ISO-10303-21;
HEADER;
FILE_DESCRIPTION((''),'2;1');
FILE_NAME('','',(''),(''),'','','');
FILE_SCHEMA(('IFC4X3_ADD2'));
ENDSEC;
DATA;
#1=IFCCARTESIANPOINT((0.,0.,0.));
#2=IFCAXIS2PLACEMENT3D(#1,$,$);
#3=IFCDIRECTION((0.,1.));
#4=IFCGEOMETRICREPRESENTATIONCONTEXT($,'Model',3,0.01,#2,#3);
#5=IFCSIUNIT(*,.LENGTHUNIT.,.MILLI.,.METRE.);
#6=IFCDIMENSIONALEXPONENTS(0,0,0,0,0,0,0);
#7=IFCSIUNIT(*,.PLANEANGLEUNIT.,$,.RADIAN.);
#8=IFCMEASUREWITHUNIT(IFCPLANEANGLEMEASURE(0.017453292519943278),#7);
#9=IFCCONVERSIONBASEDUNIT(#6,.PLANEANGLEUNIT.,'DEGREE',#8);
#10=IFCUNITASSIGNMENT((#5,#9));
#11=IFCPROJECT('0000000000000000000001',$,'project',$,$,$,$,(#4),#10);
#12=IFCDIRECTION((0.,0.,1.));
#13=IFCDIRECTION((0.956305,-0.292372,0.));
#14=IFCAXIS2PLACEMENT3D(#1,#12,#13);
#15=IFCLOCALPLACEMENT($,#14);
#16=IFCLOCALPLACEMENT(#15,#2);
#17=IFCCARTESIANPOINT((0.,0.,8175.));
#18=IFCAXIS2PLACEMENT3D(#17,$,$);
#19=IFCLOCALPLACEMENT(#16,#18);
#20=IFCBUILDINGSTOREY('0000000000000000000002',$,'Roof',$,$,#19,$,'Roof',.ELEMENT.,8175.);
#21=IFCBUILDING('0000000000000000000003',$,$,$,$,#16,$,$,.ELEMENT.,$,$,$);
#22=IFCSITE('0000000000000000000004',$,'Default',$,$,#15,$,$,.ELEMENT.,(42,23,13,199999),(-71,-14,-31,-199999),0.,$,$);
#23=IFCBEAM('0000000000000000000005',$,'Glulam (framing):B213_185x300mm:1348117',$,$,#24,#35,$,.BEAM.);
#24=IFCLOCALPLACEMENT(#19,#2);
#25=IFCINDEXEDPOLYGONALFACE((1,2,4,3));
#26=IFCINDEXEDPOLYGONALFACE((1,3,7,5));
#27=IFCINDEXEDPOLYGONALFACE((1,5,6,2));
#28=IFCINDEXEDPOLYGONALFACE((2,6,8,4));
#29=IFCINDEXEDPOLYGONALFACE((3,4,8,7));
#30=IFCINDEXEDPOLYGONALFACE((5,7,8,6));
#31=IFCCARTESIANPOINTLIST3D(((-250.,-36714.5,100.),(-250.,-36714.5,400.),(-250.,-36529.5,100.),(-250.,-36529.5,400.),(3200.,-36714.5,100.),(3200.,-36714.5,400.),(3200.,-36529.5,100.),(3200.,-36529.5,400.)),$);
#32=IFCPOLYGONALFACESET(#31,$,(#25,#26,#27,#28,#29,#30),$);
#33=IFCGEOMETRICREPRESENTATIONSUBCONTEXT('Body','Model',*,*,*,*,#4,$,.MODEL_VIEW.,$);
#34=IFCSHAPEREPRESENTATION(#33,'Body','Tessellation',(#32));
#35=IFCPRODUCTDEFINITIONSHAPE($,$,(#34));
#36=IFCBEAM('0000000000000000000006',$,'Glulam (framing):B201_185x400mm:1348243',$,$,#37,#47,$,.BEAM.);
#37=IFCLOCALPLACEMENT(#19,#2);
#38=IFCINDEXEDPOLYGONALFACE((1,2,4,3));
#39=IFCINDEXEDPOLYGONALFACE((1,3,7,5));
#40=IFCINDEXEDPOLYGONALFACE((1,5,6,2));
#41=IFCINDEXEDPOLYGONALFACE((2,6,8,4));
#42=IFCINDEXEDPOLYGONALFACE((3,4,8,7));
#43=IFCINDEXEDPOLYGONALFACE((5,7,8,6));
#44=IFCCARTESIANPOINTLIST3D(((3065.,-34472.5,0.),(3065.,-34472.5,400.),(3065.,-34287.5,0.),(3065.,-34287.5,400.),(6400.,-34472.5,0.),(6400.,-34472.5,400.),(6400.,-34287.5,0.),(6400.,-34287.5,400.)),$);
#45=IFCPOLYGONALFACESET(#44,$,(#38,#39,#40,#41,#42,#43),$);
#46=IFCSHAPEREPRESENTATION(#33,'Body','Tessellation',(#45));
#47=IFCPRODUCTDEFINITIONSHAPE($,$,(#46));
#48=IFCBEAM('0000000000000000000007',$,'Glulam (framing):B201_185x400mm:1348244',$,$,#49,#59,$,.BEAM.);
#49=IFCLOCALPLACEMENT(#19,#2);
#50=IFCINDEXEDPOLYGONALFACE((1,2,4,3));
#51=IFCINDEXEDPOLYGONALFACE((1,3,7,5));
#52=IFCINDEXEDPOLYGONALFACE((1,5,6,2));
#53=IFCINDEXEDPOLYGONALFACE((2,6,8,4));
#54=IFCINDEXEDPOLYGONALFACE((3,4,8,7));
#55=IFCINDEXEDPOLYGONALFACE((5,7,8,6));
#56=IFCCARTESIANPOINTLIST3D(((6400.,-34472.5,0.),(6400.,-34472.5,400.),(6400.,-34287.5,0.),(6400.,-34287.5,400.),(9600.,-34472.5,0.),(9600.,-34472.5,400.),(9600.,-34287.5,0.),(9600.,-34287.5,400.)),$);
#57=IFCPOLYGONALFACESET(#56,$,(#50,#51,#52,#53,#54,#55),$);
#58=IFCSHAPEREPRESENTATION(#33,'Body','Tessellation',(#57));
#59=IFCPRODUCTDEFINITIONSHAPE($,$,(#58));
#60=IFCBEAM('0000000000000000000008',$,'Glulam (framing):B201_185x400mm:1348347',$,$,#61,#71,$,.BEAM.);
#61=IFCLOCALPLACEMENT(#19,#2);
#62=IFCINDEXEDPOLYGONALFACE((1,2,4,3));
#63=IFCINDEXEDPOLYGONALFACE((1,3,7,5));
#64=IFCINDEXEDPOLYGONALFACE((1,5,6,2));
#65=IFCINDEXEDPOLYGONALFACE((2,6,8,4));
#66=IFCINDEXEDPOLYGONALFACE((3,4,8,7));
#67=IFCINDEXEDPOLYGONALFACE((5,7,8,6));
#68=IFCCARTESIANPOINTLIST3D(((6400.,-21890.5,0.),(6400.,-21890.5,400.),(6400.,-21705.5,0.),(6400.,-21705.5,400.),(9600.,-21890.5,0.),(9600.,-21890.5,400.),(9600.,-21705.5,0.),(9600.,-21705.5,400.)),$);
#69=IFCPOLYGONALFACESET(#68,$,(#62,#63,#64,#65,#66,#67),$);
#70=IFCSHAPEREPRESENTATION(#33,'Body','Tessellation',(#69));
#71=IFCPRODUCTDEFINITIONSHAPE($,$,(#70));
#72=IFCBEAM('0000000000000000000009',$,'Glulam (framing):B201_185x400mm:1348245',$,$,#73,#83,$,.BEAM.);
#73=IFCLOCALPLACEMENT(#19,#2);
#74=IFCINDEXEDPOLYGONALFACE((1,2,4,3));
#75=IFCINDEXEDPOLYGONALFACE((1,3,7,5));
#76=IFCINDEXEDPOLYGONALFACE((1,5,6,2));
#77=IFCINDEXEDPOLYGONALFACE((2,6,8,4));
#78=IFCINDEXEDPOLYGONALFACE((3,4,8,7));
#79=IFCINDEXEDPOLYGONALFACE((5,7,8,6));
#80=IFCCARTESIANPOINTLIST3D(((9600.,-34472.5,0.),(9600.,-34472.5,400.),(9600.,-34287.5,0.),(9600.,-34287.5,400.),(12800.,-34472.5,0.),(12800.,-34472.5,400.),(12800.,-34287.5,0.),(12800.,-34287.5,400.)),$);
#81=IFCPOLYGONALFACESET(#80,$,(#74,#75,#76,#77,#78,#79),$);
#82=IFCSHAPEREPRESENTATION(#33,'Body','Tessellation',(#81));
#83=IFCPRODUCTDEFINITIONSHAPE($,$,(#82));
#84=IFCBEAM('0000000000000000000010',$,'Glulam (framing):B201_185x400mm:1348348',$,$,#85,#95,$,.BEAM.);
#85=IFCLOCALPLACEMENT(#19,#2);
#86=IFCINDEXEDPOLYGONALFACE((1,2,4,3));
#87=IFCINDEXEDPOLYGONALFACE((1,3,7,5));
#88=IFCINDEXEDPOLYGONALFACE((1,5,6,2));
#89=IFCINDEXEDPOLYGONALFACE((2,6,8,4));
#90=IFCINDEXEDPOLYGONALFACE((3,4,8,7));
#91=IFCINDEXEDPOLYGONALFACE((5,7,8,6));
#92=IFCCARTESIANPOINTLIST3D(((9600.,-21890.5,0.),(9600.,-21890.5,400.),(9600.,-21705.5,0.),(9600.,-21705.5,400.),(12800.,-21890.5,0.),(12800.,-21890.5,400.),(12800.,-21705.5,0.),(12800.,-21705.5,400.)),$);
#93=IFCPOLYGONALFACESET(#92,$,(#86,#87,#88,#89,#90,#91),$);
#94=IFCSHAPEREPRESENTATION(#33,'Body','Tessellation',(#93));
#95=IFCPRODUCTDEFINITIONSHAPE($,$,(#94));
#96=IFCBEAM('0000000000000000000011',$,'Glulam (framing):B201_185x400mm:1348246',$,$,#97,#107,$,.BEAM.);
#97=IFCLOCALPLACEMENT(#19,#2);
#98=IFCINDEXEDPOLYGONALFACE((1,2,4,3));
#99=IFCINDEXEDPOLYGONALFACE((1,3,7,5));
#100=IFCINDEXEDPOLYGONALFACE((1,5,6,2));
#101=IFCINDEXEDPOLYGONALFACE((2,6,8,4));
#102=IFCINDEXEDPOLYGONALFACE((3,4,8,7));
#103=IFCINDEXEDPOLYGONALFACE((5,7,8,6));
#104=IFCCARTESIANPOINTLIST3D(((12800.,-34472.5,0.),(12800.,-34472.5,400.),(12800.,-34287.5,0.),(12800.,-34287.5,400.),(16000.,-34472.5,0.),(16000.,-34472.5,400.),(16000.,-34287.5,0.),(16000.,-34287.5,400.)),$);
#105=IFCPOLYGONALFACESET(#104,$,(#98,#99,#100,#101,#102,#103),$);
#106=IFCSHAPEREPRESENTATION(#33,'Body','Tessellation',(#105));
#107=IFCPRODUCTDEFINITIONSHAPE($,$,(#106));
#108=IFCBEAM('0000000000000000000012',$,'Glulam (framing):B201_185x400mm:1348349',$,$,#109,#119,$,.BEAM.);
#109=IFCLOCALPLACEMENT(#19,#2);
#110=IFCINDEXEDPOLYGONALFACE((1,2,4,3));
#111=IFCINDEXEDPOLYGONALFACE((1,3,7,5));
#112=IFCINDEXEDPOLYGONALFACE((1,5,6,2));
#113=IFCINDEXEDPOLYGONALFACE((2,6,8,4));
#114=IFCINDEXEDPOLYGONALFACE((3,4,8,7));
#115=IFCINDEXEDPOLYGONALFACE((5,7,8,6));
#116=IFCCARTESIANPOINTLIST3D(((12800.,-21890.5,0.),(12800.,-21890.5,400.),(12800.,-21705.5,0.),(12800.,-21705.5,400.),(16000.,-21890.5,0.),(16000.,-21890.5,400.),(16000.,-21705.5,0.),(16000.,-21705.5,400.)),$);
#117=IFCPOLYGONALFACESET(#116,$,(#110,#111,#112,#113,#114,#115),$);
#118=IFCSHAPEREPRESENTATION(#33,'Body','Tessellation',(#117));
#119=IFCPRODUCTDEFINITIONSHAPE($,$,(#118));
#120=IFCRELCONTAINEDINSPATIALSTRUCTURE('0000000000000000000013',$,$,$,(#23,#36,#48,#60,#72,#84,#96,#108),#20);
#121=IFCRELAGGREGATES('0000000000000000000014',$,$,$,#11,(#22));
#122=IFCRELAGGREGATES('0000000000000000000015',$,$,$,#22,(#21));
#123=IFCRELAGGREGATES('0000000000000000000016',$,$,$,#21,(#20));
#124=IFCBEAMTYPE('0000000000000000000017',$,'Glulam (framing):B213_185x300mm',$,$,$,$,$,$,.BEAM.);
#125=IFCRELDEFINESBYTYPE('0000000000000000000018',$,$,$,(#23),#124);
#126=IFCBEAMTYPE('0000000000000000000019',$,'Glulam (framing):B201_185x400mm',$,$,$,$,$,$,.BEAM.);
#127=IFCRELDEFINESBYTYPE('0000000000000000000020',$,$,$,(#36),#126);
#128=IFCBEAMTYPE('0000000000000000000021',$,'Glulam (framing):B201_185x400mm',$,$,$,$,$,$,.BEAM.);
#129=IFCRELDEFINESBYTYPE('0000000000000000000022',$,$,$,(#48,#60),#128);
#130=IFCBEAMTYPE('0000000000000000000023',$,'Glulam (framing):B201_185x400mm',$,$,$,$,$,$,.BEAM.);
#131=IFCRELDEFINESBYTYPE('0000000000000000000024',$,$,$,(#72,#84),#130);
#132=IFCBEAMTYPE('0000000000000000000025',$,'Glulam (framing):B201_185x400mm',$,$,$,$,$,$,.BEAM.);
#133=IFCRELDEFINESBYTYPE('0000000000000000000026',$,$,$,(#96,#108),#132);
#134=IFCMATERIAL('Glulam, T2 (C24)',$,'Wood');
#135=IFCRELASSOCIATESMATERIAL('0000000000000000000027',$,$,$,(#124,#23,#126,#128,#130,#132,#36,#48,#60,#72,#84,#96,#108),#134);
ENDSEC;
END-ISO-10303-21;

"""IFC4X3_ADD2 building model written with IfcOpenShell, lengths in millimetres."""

from ifc_helpers import new_model, entity, si_unit, converted_unit, direction, frame, origin, origin_2d_with_axis, place, context, subcontext, project, spatial, rectangle, extrude, source, transform, mapped, material, material_profile, profile_set, profile_usage, type_object, type_shapes, element, save


model = new_model("IFC4X3_ADD2")

# Units and contexts
model_context = context("Model", 3, precision=0.01, world=origin(), true_north=direction((0.0, 1.0)))
body_context = subcontext(model_context, "Body", "Model", "MODEL_VIEW")
ifc_project = project(units=[si_unit("LENGTHUNIT", "METRE", prefix="MILLI"), converted_unit("PLANEANGLEUNIT", "DEGREE", entity("IfcPlaneAngleMeasure", 0.017453292519943278), si_unit("PLANEANGLEUNIT", "RADIAN"), dimensions=[0, 0, 0, 0, 0, 0, 0])], contexts=[model_context])

# Site, building, storey
site_placement = place(None, frame((0.0, 0.0, 0.0), z_axis=(0.0, 0.0, 1.0), x_axis=(0.956305, -0.292372, 0.0)))
site = spatial("IfcSite", under=ifc_project, at=site_placement, Name="Default", CompositionType="ELEMENT", RefLatitude=(42, 23, 13, 199999), RefLongitude=(-71, -14, -31, -199999), RefElevation=0.0)
building_placement = place(site_placement, origin())
building = spatial("IfcBuilding", under=site, at=building_placement, CompositionType="ELEMENT")
storey_placement = place(building_placement, frame((0.0, 0.0, 8175.0)))
storey = spatial("IfcBuildingStorey", under=building, at=storey_placement, Name="Roof", LongName="Roof", CompositionType="ELEMENT", Elevation=8175.0)

# Beams
ifc_material = material(Name="Glulam, T2 (C24)", Category="Wood")
ifc_material_profile_1 = material_profile(ifc_material, rectangle(XDim=3200.0, YDim=185.0, at=origin_2d_with_axis()), Name="B213_185x300mm")
ifc_profile_set_1 = profile_set([ifc_material_profile_1], Name="B213_185x300mm")
ifc_profile_usage_1 = profile_usage(ifc_profile_set_1, cardinal=8)
beam_type_1 = type_object("IfcBeamType", Name="Glulam (framing):B213_185x300mm", PredefinedType="BEAM", material=ifc_profile_set_1)
shared_shape_1 = source(origin(), body_context, "Body", "SweptSolid", [
    extrude(rectangle(XDim=3450.0, YDim=185.0, at=origin_2d_with_axis()), frame((125.0, 0.0, -150.0), z_axis=(0.0, 0.0, 1.0), x_axis=(-1.0, 0.0, 0.0)), (0.0, 0.0, 1.0), 300.0),
])
type_shapes(beam_type_1, [shared_shape_1])
beam_1_placement = place(storey_placement, frame((1600.0, -36622.0, 250.0), z_axis=(0.0, 0.0, 1.0), x_axis=(-1.0, 0.0, 0.0)))
element("IfcBeam", 1, at=beam_1_placement, inside=storey, type_object=beam_type_1, material=ifc_profile_usage_1, Name="Glulam (framing):B213_185x300mm:1348117", PredefinedType="BEAM", context=body_context, shape_type="MappedRepresentation", body=[
    mapped(shared_shape_1, transform((0.0, 0.0, 0.0), scale=1.0)),
])
ifc_material_profile_2 = material_profile(ifc_material, rectangle(XDim=3335.0, YDim=185.0, at=origin_2d_with_axis()), Name="B201_185x400mm")
ifc_profile_set_2 = profile_set([ifc_material_profile_2], Name="B201_185x400mm")
ifc_profile_usage_2 = profile_usage(ifc_profile_set_2, cardinal=8)
beam_type_2 = type_object("IfcBeamType", Name="Glulam (framing):B201_185x400mm", PredefinedType="BEAM", material=ifc_profile_set_2)
shared_shape_2 = source(origin(), body_context, "Body", "SweptSolid", [
    extrude(rectangle(XDim=3335.0, YDim=185.0, at=origin_2d_with_axis()), frame((84.2, 0.0, -200.0), z_axis=(0.0, 0.0, 1.0), x_axis=(-1.0, 0.0, 0.0)), (0.0, 0.0, 1.0), 400.0),
])
type_shapes(beam_type_2, [shared_shape_2])
beam_2_placement = place(storey_placement, frame((4816.7, -34380.0, 200.0), z_axis=(0.0, 0.0, 1.0), x_axis=(-1.0, 0.0, 0.0)))
element("IfcBeam", 2, at=beam_2_placement, inside=storey, type_object=beam_type_2, material=ifc_profile_usage_2, Name="Glulam (framing):B201_185x400mm:1348243", PredefinedType="BEAM", context=body_context, shape_type="MappedRepresentation", body=[
    mapped(shared_shape_2, transform((0.0, 0.0, 0.0), scale=1.0)),
])
beam_type_3 = type_object("IfcBeamType", Name="Glulam (framing):B201_185x400mm", PredefinedType="BEAM", material=ifc_profile_set_2)
shared_shape_3 = source(origin(), body_context, "Body", "SweptSolid", [
    extrude(rectangle(XDim=3200.0, YDim=185.0, at=origin_2d_with_axis()), frame((0.0, 0.0, -200.0), z_axis=(0.0, 0.0, 1.0), x_axis=(-1.0, 0.0, 0.0)), (0.0, 0.0, 1.0), 400.0),
])
type_shapes(beam_type_3, [shared_shape_3])
for number, where, z_axis, x_axis, name in (
    (3, (8000.0, -34380.0, 200.0), (0.0, 0.0, 1.0), (-1.0, 0.0, 0.0), "Glulam (framing):B201_185x400mm:1348244"),
    (4, (8000.0, -21798.0, 200.0), (0.0, 0.0, 1.0), (-1.0, 0.0, 0.0), "Glulam (framing):B201_185x400mm:1348347"),
):
    element("IfcBeam", number, at=place(storey_placement, frame(where, z_axis=z_axis, x_axis=x_axis)), inside=storey, type_object=beam_type_3, material=ifc_profile_usage_2, Name=name, PredefinedType="BEAM", context=body_context, shape_type="MappedRepresentation", body=[
        mapped(shared_shape_3, transform((0.0, 0.0, 0.0), scale=1.0)),
    ])
beam_type_4 = type_object("IfcBeamType", Name="Glulam (framing):B201_185x400mm", PredefinedType="BEAM", material=ifc_profile_set_2)
shared_shape_4 = source(origin(), body_context, "Body", "SweptSolid", [
    extrude(rectangle(XDim=3200.0, YDim=185.0, at=origin_2d_with_axis()), frame((0.0, 0.0, -200.0), z_axis=(0.0, 0.0, 1.0), x_axis=(-1.0, 0.0, 0.0)), (0.0, 0.0, 1.0), 400.0),
])
type_shapes(beam_type_4, [shared_shape_4])
for number, where, z_axis, x_axis, name in (
    (5, (11200.0, -34380.0, 200.0), (0.0, 0.0, 1.0), (-1.0, 0.0, 0.0), "Glulam (framing):B201_185x400mm:1348245"),
    (6, (11200.0, -21798.0, 200.0), (0.0, 0.0, 1.0), (-1.0, 0.0, 0.0), "Glulam (framing):B201_185x400mm:1348348"),
):
    element("IfcBeam", number, at=place(storey_placement, frame(where, z_axis=z_axis, x_axis=x_axis)), inside=storey, type_object=beam_type_4, material=ifc_profile_usage_2, Name=name, PredefinedType="BEAM", context=body_context, shape_type="MappedRepresentation", body=[
        mapped(shared_shape_4, transform((0.0, 0.0, 0.0), scale=1.0)),
    ])
beam_type_5 = type_object("IfcBeamType", Name="Glulam (framing):B201_185x400mm", PredefinedType="BEAM", material=ifc_profile_set_2)
shared_shape_5 = source(origin(), body_context, "Body", "SweptSolid", [
    extrude(rectangle(XDim=3200.0, YDim=185.0, at=origin_2d_with_axis()), frame((0.0, 0.0, -200.0), z_axis=(0.0, 0.0, 1.0), x_axis=(-1.0, 0.0, 0.0)), (0.0, 0.0, 1.0), 400.0),
])
type_shapes(beam_type_5, [shared_shape_5])
for number, where, z_axis, x_axis, name in (
    (7, (14400.0, -34380.0, 200.0), (0.0, 0.0, 1.0), (-1.0, 0.0, 0.0), "Glulam (framing):B201_185x400mm:1348246"),
    (8, (14400.0, -21798.0, 200.0), (0.0, 0.0, 1.0), (-1.0, 0.0, 0.0), "Glulam (framing):B201_185x400mm:1348349"),
):
    element("IfcBeam", number, at=place(storey_placement, frame(where, z_axis=z_axis, x_axis=x_axis)), inside=storey, type_object=beam_type_5, material=ifc_profile_usage_2, Name=name, PredefinedType="BEAM", context=body_context, shape_type="MappedRepresentation", body=[
        mapped(shared_shape_5, transform((0.0, 0.0, 0.0), scale=1.0)),
    ])

save(model, "model.ifc")
